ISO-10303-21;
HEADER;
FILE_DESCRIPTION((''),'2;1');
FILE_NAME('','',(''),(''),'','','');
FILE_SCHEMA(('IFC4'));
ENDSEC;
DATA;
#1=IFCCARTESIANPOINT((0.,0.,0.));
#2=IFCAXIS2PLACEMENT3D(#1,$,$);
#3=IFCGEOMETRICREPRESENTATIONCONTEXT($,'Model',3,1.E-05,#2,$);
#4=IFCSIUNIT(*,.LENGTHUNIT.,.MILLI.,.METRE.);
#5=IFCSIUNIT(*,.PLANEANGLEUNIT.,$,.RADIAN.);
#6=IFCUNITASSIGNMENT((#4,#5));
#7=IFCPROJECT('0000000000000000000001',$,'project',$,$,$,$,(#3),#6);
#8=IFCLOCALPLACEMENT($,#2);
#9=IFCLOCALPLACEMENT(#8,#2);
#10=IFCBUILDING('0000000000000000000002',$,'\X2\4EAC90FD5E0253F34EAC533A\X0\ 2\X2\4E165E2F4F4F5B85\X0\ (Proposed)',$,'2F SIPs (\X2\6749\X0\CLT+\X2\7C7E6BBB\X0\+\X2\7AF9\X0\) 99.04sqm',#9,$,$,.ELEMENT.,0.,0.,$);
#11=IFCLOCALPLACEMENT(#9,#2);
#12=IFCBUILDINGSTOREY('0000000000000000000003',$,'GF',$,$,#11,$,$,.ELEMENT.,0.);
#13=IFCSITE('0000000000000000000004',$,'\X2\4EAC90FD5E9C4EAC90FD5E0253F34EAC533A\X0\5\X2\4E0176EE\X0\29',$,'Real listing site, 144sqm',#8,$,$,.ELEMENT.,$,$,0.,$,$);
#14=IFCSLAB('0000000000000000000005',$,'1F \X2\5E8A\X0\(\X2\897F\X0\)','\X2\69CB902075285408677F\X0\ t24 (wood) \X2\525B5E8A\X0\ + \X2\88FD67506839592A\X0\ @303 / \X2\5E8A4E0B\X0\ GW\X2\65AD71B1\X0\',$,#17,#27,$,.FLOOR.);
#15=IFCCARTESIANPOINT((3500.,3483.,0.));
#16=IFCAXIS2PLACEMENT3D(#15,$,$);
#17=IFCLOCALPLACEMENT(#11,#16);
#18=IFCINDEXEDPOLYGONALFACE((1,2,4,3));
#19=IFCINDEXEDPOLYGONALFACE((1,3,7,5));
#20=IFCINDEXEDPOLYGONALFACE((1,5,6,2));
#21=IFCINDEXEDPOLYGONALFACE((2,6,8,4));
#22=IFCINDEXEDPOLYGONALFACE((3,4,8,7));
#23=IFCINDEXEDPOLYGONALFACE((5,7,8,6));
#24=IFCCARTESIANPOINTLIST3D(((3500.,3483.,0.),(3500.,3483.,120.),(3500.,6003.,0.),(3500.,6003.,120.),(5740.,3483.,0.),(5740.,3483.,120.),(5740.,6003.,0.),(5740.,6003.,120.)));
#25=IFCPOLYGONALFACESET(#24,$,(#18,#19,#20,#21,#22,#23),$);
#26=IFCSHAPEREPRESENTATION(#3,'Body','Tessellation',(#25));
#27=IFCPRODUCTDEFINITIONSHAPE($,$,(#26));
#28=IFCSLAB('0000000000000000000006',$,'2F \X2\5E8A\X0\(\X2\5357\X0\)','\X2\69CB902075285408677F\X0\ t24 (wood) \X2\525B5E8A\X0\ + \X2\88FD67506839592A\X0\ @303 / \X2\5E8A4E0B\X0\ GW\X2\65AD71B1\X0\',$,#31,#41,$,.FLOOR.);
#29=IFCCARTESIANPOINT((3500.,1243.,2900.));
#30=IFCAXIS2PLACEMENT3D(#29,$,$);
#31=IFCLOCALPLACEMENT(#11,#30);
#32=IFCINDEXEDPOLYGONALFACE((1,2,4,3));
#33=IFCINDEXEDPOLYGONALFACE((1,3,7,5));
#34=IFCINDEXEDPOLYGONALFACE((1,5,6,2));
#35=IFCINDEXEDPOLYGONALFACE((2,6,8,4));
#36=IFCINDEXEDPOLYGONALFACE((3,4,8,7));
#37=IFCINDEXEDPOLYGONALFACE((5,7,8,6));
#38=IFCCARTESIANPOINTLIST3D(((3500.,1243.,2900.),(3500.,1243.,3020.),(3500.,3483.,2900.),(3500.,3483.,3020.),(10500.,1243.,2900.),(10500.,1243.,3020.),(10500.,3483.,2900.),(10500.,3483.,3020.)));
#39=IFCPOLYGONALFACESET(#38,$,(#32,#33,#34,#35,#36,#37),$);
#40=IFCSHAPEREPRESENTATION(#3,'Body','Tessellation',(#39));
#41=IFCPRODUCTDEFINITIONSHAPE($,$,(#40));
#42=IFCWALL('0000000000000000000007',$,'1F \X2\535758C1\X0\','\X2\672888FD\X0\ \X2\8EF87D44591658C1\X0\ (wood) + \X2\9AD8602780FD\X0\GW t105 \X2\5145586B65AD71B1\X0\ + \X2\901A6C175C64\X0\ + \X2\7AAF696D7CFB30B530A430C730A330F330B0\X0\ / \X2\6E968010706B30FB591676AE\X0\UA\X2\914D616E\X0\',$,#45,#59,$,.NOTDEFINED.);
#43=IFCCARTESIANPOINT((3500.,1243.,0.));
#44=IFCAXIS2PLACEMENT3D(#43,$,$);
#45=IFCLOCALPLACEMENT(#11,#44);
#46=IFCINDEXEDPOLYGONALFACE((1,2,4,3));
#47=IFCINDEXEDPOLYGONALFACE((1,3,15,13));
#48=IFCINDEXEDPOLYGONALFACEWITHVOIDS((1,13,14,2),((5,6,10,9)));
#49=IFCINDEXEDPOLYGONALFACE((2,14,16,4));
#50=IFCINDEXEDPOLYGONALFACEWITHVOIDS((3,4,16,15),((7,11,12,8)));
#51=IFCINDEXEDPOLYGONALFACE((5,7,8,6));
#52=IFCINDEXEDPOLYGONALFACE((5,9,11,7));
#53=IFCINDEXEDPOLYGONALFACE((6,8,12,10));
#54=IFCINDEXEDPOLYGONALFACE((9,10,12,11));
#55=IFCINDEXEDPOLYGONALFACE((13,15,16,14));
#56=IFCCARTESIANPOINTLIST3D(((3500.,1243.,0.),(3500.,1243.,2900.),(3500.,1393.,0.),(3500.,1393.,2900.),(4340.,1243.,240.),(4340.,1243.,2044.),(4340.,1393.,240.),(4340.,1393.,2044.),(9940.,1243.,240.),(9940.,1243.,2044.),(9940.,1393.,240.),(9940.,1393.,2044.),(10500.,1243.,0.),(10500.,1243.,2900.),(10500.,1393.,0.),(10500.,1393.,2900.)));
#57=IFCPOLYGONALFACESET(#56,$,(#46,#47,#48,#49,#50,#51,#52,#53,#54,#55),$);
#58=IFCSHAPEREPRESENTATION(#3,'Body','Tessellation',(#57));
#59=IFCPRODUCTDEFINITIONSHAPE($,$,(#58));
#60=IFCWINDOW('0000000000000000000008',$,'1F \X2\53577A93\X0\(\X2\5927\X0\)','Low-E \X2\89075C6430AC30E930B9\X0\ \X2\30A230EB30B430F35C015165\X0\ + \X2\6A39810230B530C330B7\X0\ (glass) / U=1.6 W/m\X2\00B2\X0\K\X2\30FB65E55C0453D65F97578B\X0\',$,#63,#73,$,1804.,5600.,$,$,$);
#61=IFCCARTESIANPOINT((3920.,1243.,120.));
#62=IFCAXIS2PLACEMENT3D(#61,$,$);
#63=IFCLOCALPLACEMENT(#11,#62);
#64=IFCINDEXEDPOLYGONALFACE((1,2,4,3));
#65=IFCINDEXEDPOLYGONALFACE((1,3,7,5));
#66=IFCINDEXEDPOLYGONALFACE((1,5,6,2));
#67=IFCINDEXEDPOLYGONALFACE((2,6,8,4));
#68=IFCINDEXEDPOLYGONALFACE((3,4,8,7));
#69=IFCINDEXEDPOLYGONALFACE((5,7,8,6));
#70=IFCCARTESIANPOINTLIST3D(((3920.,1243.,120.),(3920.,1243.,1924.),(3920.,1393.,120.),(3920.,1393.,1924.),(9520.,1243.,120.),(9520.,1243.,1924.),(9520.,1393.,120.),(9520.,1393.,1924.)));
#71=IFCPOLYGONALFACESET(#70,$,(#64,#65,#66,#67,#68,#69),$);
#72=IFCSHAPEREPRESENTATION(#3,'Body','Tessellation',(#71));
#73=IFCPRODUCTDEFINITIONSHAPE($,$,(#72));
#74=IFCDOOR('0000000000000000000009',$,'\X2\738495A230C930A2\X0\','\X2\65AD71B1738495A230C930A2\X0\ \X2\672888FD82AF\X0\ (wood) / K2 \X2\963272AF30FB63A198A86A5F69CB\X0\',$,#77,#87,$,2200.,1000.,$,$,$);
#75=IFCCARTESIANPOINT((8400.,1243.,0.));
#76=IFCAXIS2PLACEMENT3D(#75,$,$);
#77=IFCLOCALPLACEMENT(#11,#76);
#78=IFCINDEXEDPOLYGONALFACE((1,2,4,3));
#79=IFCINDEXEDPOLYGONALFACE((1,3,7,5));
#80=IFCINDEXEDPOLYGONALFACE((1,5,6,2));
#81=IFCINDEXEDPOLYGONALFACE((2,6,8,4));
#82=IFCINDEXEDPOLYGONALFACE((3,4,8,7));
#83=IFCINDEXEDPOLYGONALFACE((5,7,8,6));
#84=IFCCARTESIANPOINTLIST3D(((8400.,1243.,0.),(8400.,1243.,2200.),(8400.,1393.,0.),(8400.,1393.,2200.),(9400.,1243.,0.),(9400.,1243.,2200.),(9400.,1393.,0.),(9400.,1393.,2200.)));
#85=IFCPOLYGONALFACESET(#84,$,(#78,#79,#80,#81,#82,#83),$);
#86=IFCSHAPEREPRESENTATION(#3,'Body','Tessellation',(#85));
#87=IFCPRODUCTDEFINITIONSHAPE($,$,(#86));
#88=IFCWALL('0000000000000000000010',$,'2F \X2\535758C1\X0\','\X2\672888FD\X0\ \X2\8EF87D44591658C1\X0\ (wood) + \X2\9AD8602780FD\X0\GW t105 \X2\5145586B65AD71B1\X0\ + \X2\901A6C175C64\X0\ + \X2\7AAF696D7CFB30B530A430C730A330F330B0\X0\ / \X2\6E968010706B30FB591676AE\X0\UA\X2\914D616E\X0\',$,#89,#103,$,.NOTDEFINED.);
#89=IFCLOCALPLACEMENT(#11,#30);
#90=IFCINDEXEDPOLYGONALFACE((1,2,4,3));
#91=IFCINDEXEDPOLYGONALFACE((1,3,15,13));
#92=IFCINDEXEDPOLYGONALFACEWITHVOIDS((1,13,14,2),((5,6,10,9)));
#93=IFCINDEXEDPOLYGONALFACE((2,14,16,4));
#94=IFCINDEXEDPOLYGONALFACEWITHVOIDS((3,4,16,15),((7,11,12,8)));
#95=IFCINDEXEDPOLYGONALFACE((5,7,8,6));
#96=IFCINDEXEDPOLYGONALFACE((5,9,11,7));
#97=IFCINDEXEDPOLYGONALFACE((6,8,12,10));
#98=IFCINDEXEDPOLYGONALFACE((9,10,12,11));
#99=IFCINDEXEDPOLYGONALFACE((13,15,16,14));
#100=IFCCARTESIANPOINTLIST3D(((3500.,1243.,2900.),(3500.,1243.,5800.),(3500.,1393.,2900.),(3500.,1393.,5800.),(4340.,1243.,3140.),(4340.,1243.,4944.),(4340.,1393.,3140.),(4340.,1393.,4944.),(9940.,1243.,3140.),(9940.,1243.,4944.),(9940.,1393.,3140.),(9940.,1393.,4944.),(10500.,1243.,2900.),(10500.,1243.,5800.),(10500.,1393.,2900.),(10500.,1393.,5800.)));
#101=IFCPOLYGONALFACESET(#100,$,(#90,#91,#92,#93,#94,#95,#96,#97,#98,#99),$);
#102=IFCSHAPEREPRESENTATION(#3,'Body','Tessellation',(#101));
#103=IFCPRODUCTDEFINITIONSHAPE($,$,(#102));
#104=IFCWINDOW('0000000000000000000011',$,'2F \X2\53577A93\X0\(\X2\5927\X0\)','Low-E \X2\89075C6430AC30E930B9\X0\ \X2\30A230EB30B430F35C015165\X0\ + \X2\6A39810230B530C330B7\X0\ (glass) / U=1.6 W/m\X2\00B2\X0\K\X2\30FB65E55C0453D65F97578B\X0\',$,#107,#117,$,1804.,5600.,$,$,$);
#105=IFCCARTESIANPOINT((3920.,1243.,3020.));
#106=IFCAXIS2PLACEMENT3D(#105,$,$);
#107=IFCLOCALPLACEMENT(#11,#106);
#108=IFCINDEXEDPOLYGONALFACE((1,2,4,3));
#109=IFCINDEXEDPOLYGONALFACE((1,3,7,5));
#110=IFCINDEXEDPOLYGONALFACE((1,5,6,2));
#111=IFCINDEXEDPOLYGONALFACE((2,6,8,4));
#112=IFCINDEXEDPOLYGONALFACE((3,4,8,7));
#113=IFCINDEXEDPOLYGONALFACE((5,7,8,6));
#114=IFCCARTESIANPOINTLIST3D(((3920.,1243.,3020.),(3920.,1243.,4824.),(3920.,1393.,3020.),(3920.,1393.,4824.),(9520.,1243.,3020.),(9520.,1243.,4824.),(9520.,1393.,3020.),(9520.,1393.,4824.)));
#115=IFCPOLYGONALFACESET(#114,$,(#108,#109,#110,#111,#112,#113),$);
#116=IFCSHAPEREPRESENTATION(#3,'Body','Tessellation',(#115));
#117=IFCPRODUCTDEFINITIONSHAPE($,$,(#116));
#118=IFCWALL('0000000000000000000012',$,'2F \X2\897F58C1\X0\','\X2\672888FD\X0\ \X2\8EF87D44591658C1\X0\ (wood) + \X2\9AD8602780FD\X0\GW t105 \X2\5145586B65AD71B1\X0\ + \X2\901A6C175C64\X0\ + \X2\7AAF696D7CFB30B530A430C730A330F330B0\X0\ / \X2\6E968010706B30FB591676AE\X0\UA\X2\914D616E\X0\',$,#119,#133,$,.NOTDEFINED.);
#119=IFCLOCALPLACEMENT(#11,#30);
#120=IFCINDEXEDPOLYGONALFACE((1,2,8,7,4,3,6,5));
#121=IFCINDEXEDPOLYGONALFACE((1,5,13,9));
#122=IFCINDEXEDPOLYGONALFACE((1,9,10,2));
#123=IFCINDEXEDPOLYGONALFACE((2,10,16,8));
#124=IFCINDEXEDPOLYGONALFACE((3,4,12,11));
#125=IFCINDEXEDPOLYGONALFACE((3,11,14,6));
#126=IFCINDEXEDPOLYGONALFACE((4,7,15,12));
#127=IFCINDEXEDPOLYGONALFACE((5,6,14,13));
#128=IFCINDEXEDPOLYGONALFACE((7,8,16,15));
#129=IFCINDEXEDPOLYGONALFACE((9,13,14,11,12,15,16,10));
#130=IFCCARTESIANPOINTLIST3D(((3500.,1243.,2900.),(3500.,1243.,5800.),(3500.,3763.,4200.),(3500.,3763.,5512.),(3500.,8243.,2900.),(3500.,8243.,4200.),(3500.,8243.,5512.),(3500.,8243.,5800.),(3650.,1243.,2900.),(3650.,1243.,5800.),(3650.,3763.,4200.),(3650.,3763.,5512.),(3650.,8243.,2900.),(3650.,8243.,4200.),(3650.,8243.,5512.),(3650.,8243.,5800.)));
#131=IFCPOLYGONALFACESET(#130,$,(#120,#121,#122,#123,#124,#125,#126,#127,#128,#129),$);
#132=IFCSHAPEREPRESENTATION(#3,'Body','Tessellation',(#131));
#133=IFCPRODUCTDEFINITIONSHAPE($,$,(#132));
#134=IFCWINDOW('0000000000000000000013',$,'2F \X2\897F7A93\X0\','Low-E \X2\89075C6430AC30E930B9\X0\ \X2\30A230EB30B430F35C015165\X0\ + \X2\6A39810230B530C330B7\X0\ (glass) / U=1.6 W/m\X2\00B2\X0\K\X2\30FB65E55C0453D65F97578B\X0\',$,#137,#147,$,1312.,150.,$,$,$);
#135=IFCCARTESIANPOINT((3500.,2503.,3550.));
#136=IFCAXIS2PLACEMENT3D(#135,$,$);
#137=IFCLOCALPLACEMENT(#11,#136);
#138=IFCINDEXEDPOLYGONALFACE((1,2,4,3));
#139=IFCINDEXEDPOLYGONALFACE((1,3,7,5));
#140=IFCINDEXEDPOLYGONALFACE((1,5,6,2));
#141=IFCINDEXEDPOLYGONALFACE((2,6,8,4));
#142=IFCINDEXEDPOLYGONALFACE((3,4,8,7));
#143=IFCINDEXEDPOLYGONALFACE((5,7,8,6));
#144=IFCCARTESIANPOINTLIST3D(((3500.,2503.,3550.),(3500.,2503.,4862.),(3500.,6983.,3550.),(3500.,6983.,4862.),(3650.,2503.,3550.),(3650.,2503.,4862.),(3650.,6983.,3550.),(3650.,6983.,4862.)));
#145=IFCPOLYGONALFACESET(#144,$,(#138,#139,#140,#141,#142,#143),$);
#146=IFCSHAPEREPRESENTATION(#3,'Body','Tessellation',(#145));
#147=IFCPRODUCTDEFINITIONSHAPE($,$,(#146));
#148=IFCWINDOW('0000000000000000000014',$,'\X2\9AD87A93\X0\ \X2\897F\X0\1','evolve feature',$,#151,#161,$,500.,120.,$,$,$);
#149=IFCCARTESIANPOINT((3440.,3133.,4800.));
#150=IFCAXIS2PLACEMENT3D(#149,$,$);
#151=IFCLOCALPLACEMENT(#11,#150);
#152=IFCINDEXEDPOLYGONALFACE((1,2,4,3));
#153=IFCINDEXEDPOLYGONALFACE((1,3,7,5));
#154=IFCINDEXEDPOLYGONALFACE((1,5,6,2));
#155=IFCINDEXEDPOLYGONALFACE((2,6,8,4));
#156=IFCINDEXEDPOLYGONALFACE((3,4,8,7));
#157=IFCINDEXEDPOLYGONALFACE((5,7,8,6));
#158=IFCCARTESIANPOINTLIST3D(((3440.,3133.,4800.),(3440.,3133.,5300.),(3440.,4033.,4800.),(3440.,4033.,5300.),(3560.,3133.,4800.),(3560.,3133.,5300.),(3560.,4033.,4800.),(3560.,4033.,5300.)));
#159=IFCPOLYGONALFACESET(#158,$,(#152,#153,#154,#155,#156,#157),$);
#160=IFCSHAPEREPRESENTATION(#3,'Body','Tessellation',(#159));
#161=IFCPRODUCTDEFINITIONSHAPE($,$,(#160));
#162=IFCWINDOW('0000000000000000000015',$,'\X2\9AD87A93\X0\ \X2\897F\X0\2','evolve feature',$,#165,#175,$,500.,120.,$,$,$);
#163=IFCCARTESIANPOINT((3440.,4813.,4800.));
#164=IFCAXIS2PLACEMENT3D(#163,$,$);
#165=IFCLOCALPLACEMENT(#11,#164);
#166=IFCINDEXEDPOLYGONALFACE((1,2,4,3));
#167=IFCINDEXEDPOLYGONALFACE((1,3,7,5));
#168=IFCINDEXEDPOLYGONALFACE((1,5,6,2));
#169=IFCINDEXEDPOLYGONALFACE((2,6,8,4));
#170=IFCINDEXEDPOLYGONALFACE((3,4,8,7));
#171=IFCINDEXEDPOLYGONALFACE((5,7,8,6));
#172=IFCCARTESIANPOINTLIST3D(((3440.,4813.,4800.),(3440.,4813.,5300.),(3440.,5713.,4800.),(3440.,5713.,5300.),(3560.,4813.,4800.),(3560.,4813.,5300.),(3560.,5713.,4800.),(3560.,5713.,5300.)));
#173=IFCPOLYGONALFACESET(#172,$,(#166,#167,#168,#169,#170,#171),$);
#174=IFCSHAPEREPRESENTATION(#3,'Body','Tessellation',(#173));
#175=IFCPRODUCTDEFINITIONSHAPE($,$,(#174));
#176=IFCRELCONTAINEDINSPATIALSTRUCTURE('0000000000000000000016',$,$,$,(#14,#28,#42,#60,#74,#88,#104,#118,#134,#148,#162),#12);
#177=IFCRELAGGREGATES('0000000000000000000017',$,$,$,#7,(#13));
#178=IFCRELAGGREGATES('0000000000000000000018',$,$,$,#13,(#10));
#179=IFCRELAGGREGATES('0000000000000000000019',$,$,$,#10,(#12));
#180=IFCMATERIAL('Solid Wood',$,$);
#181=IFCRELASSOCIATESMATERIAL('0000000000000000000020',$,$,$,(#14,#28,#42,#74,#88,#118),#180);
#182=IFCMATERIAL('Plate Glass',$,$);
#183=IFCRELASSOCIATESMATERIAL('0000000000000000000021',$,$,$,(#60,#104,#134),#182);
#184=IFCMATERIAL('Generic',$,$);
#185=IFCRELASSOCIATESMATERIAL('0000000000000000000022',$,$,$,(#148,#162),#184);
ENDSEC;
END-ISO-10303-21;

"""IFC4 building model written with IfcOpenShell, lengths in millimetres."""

from ifc_helpers import new_model, si_unit, frame, frame_2d, origin, place, context, project, spatial, rectangle, extrude, material, element, fill, save


model = new_model("IFC4")

# Units and contexts
model_context = context("Model", 3, precision=1e-05, world=origin())
ifc_project = project(units=[si_unit("LENGTHUNIT", "METRE", prefix="MILLI"), si_unit("PLANEANGLEUNIT", "RADIAN")], contexts=[model_context])

# Site, building, storey
site_placement = place(None, origin())
site = spatial("IfcSite", under=ifc_project, at=site_placement, Name="京都府京都市右京区5丁目29", ObjectType="Real listing site, 144sqm", CompositionType="ELEMENT", RefElevation=0.0)
building_placement = place(site_placement, origin())
building = spatial("IfcBuilding", under=site, at=building_placement, Name="京都市右京区 2世帯住宅 (Proposed)", ObjectType="2F SIPs (杉CLT+籾殻+竹) 99.04sqm", CompositionType="ELEMENT", ElevationOfRefHeight=0.0, ElevationOfTerrain=0.0)
storey_placement = place(building_placement, origin())
storey = spatial("IfcBuildingStorey", under=building, at=storey_placement, Name="GF", CompositionType="ELEMENT", Elevation=0.0)

# Slabs
ifc_material_1 = material(Name="Solid Wood")
slab_1_placement = place(storey_placement, frame((3500.0, 3483.0, 0.0)))
element("IfcSlab", 1, at=slab_1_placement, inside=storey, material=ifc_material_1, Name="1F 床(西)", Description="構造用合板 t24 (wood) 剛床 + 製材根太 @303 / 床下 GW断熱", PredefinedType="FLOOR", context=model_context, shape_type="SweptSolid", body=[
    extrude(rectangle(XDim=2240.0, YDim=2520.0, at=frame_2d((1120.0, 1260.0))), frame((3500.0, 3483.0, 0.0)), (0.0, 0.0, 1.0), 120.0),
])
slab_2_placement = place(storey_placement, frame((3500.0, 1243.0, 2900.0)))
element("IfcSlab", 2, at=slab_2_placement, inside=storey, material=ifc_material_1, Name="2F 床(南)", Description="構造用合板 t24 (wood) 剛床 + 製材根太 @303 / 床下 GW断熱", PredefinedType="FLOOR", context=model_context, shape_type="SweptSolid", body=[
    extrude(rectangle(XDim=7000.0, YDim=2240.0, at=frame_2d((3500.0, 1120.0))), frame((3500.0, 1243.0, 2900.0)), (0.0, 0.0, 1.0), 120.0),
])
ifc_material_2 = material(Name="Generic")

# Wall, openings, window, door
wall_1_placement = place(storey_placement, frame((3500.0, 1243.0, 0.0)))
wall_1 = element("IfcWall", 3, at=wall_1_placement, inside=storey, material=ifc_material_1, Name="1F 南壁", Description="木製 軸組外壁 (wood) + 高性能GW t105 充填断熱 + 通気層 + 窯業系サイディング / 準耐火・外皮UA配慮", PredefinedType="NOTDEFINED", context=model_context, shape_type="SweptSolid", body=[
    extrude(rectangle(XDim=7000.0, YDim=150.0, at=frame_2d((3500.0, 75.0))), frame((3500.0, 1243.0, 0.0)), (0.0, 0.0, 1.0), 2900.0),
])
opening_1_placement = place(storey_placement, frame((3920.0, 1243.0, 120.0)))
opening_1 = element("IfcOpeningElement", 4, at=opening_1_placement, cuts=wall_1, PredefinedType="NOTDEFINED", context=model_context, shape_type="SweptSolid", body=[
    extrude(rectangle(XDim=5600.0, YDim=150.0, at=frame_2d((2800.0, 75.0))), frame((3920.0, 1243.0, 120.0)), (0.0, 0.0, 1.0), 1804.0),
])
opening_2_placement = place(storey_placement, frame((8400.0, 1243.0, 0.0)))
opening_2 = element("IfcOpeningElement", 5, at=opening_2_placement, cuts=wall_1, PredefinedType="NOTDEFINED", context=model_context, shape_type="SweptSolid", body=[
    extrude(rectangle(XDim=1000.0, YDim=150.0, at=frame_2d((500.0, 75.0))), frame((8400.0, 1243.0, 0.0)), (0.0, 0.0, 1.0), 2200.0),
])
ifc_material_3 = material(Name="Plate Glass")
window_1_placement = place(storey_placement, frame((3920.0, 1243.0, 120.0)))
window_1 = element("IfcWindow", 6, at=window_1_placement, inside=storey, material=ifc_material_3, Name="1F 南窓(大)", Description="Low-E 複層ガラス アルゴン封入 + 樹脂サッシ (glass) / U=1.6 W/m²K・日射取得型", OverallHeight=1804.0, OverallWidth=5600.0, context=model_context, shape_type="SweptSolid", body=[
    extrude(rectangle(XDim=5600.0, YDim=150.0, at=frame_2d((2800.0, 75.0))), frame((3920.0, 1243.0, 120.0)), (0.0, 0.0, 1.0), 1804.0),
])
fill(opening_1, window_1)
door_placement = place(storey_placement, frame((8400.0, 1243.0, 0.0)))
door = element("IfcDoor", 7, at=door_placement, inside=storey, material=ifc_material_1, Name="玄関ドア", Description="断熱玄関ドア 木製芯 (wood) / K2 防犯・採風機構", OverallHeight=2200.0, OverallWidth=1000.0, context=model_context, shape_type="SweptSolid", body=[
    extrude(rectangle(XDim=1000.0, YDim=150.0, at=frame_2d((500.0, 75.0))), frame((8400.0, 1243.0, 0.0)), (0.0, 0.0, 1.0), 2200.0),
])
fill(opening_2, door)

# Wall, opening, window
wall_2_placement = place(storey_placement, frame((3500.0, 1243.0, 2900.0)))
wall_2 = element("IfcWall", 8, at=wall_2_placement, inside=storey, material=ifc_material_1, Name="2F 南壁", Description="木製 軸組外壁 (wood) + 高性能GW t105 充填断熱 + 通気層 + 窯業系サイディング / 準耐火・外皮UA配慮", PredefinedType="NOTDEFINED", context=model_context, shape_type="SweptSolid", body=[
    extrude(rectangle(XDim=7000.0, YDim=150.0, at=frame_2d((3500.0, 75.0))), frame((3500.0, 1243.0, 2900.0)), (0.0, 0.0, 1.0), 2900.0),
])
opening_3_placement = place(storey_placement, frame((3920.0, 1243.0, 3020.0)))
opening_3 = element("IfcOpeningElement", 9, at=opening_3_placement, cuts=wall_2, PredefinedType="NOTDEFINED", context=model_context, shape_type="SweptSolid", body=[
    extrude(rectangle(XDim=5600.0, YDim=150.0, at=frame_2d((2800.0, 75.0))), frame((3920.0, 1243.0, 3020.0)), (0.0, 0.0, 1.0), 1804.0),
])
window_2_placement = place(storey_placement, frame((3920.0, 1243.0, 3020.0)))
window_2 = element("IfcWindow", 10, at=window_2_placement, inside=storey, material=ifc_material_3, Name="2F 南窓(大)", Description="Low-E 複層ガラス アルゴン封入 + 樹脂サッシ (glass) / U=1.6 W/m²K・日射取得型", OverallHeight=1804.0, OverallWidth=5600.0, context=model_context, shape_type="SweptSolid", body=[
    extrude(rectangle(XDim=5600.0, YDim=150.0, at=frame_2d((2800.0, 75.0))), frame((3920.0, 1243.0, 3020.0)), (0.0, 0.0, 1.0), 1804.0),
])
fill(opening_3, window_2)

# Wall, openings, windows
wall_3_placement = place(storey_placement, frame((3500.0, 1243.0, 2900.0)))
wall_3 = element("IfcWall", 11, at=wall_3_placement, inside=storey, material=ifc_material_1, Name="2F 西壁", Description="木製 軸組外壁 (wood) + 高性能GW t105 充填断熱 + 通気層 + 窯業系サイディング / 準耐火・外皮UA配慮", PredefinedType="NOTDEFINED", context=model_context, shape_type="SweptSolid", body=[
    extrude(rectangle(XDim=150.0, YDim=7000.0, at=frame_2d((75.0, 3500.0))), frame((3500.0, 1243.0, 2900.0)), (0.0, 0.0, 1.0), 2900.0),
])
opening_4_placement = place(storey_placement, frame((3500.0, 2503.0, 3550.0)))
opening_4 = element("IfcOpeningElement", 12, at=opening_4_placement, cuts=wall_3, PredefinedType="NOTDEFINED", context=model_context, shape_type="SweptSolid", body=[
    extrude(rectangle(XDim=150.0, YDim=4480.0, at=frame_2d((75.0, 2240.0))), frame((3500.0, 2503.0, 3550.0)), (0.0, 0.0, 1.0), 1312.0),
])
opening_5_placement = place(storey_placement, frame((3440.0, 3133.0, 4800.0)))
opening_5 = element("IfcOpeningElement", 13, at=opening_5_placement, cuts=wall_3, PredefinedType="NOTDEFINED", context=model_context, shape_type="SweptSolid", body=[
    extrude(rectangle(XDim=120.0, YDim=900.0, at=frame_2d((60.0, 450.0))), frame((3440.0, 3133.0, 4800.0)), (0.0, 0.0, 1.0), 500.0),
])
opening_6_placement = place(storey_placement, frame((3440.0, 4813.0, 4800.0)))
opening_6 = element("IfcOpeningElement", 14, at=opening_6_placement, cuts=wall_3, PredefinedType="NOTDEFINED", context=model_context, shape_type="SweptSolid", body=[
    extrude(rectangle(XDim=120.0, YDim=900.0, at=frame_2d((60.0, 450.0))), frame((3440.0, 4813.0, 4800.0)), (0.0, 0.0, 1.0), 500.0),
])
window_3_placement = place(storey_placement, frame((3500.0, 2503.0, 3550.0)))
window_3 = element("IfcWindow", 15, at=window_3_placement, inside=storey, material=ifc_material_3, Name="2F 西窓", Description="Low-E 複層ガラス アルゴン封入 + 樹脂サッシ (glass) / U=1.6 W/m²K・日射取得型", OverallHeight=1312.0, OverallWidth=150.0, context=model_context, shape_type="SweptSolid", body=[
    extrude(rectangle(XDim=150.0, YDim=4480.0, at=frame_2d((75.0, 2240.0))), frame((3500.0, 2503.0, 3550.0)), (0.0, 0.0, 1.0), 1312.0),
])
fill(opening_4, window_3)
window_4_placement = place(storey_placement, frame((3440.0, 3133.0, 4800.0)))
window_4 = element("IfcWindow", 16, at=window_4_placement, inside=storey, material=ifc_material_2, Name="高窓 西1", Description="evolve feature", OverallHeight=500.0, OverallWidth=120.0, context=model_context, shape_type="SweptSolid", body=[
    extrude(rectangle(XDim=120.0, YDim=900.0, at=frame_2d((60.0, 450.0))), frame((3440.0, 3133.0, 4800.0)), (0.0, 0.0, 1.0), 500.0),
])
fill(opening_5, window_4)
window_5_placement = place(storey_placement, frame((3440.0, 4813.0, 4800.0)))
window_5 = element("IfcWindow", 17, at=window_5_placement, inside=storey, material=ifc_material_2, Name="高窓 西2", Description="evolve feature", OverallHeight=500.0, OverallWidth=120.0, context=model_context, shape_type="SweptSolid", body=[
    extrude(rectangle(XDim=120.0, YDim=900.0, at=frame_2d((60.0, 450.0))), frame((3440.0, 4813.0, 4800.0)), (0.0, 0.0, 1.0), 500.0),
])
fill(opening_6, window_5)

save(model, "model.ifc")
